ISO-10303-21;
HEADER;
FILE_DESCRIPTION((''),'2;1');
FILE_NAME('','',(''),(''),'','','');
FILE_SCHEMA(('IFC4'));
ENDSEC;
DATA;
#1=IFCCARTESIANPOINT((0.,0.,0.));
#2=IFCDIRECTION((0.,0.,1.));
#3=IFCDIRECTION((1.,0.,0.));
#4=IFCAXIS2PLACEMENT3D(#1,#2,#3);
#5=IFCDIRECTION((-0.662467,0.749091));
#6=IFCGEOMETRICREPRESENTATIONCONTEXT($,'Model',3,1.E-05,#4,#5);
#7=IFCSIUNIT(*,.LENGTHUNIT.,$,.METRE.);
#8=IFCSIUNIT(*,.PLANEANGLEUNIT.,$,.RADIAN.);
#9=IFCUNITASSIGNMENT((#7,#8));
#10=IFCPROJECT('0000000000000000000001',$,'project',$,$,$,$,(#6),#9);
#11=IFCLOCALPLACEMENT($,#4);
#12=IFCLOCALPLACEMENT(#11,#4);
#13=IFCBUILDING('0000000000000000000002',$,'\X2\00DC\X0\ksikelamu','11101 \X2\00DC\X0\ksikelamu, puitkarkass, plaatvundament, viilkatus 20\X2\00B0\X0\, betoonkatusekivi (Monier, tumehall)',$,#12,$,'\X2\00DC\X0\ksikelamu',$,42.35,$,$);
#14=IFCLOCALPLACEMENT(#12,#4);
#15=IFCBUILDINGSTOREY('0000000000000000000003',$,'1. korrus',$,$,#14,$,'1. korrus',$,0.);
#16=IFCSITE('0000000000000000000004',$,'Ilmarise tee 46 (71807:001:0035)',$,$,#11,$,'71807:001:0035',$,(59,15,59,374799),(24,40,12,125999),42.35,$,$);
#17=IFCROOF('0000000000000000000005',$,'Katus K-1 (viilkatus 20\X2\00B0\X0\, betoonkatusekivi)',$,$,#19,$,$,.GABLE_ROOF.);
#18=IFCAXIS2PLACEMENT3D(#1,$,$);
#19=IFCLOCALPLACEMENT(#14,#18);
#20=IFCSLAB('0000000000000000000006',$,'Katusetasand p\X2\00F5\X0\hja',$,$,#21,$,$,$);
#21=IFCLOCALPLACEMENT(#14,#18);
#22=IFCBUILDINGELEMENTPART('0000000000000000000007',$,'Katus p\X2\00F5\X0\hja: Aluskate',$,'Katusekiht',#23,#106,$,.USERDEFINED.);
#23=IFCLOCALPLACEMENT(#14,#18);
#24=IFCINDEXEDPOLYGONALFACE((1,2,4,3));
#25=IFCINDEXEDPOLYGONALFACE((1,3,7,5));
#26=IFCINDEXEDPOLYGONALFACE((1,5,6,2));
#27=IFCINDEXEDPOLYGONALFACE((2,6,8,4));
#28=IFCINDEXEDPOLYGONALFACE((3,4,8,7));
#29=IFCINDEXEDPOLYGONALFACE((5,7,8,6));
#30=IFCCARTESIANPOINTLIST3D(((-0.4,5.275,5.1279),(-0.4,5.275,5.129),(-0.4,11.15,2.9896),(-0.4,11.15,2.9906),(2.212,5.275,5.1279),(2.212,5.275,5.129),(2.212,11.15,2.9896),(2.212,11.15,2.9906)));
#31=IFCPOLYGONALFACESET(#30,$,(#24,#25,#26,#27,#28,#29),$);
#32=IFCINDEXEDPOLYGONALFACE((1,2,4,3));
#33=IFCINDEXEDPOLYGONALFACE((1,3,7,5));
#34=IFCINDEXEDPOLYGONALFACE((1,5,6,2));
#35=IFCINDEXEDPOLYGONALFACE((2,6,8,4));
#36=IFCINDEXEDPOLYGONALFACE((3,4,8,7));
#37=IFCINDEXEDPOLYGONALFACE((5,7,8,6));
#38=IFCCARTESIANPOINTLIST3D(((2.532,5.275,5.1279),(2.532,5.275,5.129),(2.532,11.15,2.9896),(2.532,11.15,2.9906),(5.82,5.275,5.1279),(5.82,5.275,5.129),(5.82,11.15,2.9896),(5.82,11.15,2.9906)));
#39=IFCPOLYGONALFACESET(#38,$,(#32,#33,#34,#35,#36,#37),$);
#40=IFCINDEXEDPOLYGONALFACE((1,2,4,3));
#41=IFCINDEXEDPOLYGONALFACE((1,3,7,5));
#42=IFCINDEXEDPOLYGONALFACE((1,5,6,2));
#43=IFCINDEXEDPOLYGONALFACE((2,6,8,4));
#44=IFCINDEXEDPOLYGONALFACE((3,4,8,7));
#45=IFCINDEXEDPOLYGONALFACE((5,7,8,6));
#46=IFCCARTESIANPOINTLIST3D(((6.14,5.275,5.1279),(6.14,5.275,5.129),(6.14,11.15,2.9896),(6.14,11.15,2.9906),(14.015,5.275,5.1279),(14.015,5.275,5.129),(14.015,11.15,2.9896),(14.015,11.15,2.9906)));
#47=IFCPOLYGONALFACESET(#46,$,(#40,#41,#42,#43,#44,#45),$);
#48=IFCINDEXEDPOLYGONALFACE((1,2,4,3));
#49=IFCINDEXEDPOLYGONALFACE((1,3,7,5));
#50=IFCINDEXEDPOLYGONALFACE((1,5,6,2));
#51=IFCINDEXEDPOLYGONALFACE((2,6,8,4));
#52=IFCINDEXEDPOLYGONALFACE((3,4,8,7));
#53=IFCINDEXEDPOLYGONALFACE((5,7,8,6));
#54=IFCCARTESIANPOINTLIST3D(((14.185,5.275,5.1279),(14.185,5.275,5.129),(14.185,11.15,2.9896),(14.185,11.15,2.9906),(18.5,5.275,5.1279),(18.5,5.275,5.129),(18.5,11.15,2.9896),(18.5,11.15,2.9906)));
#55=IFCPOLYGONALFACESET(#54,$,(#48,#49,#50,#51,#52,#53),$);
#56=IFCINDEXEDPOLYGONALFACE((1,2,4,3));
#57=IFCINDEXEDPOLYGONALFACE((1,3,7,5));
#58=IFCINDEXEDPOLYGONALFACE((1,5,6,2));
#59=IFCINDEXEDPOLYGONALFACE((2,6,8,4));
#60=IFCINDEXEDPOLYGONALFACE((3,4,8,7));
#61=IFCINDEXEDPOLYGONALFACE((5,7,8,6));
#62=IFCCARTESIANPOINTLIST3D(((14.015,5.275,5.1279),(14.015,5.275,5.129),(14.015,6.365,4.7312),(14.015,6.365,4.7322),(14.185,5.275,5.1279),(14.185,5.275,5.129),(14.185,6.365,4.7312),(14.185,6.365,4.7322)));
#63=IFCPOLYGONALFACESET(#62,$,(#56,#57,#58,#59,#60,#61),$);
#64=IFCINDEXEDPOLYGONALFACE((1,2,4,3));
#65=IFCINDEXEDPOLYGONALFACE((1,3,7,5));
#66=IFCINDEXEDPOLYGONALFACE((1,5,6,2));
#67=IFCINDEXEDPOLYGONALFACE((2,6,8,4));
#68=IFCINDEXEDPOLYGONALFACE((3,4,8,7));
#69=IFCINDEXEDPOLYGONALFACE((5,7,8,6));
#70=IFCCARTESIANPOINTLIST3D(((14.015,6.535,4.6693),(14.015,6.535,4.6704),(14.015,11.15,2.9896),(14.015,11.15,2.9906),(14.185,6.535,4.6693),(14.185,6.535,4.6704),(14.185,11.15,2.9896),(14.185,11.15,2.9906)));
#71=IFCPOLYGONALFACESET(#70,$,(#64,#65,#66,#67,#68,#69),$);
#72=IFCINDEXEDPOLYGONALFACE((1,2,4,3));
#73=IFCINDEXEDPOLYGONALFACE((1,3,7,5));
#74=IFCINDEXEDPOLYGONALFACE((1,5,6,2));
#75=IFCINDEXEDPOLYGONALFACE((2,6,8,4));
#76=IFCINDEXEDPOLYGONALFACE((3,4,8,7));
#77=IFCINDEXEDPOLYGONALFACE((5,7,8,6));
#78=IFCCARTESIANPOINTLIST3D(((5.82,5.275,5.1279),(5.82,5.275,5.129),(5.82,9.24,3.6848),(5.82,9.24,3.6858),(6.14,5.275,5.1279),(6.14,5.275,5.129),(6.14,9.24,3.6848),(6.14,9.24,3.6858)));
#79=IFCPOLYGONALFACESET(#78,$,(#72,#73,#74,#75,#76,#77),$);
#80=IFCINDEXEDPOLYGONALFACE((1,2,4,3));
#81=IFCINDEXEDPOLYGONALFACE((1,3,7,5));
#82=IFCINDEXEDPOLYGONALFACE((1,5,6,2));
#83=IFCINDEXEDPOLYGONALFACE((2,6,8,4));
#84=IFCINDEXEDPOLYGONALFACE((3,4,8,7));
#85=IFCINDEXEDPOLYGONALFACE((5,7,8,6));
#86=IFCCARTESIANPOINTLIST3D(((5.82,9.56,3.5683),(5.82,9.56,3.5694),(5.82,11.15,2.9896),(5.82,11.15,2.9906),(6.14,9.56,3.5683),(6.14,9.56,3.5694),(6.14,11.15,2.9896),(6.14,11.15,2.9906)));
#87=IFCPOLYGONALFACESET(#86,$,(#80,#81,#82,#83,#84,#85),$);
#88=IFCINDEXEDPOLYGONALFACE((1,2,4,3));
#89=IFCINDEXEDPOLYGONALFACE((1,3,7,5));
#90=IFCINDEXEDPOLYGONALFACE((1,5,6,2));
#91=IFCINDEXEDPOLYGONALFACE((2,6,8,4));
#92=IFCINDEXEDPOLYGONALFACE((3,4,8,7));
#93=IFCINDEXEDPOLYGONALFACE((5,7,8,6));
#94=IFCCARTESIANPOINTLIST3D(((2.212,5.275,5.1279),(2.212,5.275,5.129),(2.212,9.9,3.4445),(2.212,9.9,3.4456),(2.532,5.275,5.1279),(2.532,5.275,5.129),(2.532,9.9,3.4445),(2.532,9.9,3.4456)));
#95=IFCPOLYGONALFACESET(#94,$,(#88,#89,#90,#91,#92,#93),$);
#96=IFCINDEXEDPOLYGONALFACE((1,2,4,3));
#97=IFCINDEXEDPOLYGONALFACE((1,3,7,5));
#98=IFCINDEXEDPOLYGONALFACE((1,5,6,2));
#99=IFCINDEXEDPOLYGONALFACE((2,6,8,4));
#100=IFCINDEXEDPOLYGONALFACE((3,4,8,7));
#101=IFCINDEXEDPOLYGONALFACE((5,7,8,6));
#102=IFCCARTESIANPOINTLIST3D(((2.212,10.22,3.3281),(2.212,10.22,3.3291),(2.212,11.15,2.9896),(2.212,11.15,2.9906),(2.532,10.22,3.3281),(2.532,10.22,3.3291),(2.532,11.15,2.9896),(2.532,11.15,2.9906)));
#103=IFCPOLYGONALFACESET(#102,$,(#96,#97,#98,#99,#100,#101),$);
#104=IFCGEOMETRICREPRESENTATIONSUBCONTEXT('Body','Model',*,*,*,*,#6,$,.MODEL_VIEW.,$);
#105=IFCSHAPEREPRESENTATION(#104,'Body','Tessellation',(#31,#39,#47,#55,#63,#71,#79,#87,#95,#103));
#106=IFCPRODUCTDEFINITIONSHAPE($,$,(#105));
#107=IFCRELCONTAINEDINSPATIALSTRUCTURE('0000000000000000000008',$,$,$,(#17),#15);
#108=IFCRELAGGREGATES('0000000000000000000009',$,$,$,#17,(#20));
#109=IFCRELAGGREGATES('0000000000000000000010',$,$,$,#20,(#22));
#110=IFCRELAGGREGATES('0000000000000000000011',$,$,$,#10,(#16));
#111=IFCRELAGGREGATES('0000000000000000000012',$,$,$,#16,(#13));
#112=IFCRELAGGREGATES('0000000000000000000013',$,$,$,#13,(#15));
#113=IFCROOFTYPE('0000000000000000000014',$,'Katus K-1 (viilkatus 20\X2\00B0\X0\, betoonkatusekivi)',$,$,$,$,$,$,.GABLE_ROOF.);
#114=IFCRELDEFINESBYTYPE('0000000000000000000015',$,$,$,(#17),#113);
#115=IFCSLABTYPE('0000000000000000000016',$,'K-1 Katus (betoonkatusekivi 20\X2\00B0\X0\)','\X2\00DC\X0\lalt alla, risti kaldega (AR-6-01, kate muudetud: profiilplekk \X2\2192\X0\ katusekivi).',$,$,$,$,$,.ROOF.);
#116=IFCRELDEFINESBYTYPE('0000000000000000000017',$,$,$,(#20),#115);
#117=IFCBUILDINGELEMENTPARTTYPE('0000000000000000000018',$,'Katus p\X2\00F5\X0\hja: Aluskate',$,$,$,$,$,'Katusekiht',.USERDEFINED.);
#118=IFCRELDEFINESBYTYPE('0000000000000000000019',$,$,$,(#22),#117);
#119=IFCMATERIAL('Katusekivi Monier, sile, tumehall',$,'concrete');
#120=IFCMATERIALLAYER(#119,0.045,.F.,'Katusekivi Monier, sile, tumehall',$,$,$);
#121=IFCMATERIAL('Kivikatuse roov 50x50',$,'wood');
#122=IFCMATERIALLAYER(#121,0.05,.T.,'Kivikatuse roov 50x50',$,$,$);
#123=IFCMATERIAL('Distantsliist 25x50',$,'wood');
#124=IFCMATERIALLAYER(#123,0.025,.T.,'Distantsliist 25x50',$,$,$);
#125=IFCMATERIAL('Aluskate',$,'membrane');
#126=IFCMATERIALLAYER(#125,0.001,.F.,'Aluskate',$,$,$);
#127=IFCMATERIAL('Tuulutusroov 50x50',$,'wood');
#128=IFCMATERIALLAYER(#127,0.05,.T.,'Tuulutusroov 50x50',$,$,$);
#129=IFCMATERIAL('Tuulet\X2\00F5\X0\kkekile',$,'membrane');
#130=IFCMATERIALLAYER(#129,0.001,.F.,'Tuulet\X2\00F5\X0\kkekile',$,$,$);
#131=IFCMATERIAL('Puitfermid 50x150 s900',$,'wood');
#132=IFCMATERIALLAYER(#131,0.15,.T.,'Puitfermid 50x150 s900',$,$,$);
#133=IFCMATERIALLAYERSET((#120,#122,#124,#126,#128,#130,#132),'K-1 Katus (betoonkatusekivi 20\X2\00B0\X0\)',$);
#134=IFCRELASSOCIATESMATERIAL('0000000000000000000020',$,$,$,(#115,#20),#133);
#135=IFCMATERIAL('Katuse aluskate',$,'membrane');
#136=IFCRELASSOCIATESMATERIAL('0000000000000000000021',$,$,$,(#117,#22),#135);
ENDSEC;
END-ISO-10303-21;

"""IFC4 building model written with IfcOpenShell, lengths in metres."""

from ifc_helpers import new_model, si_unit, direction, frame, origin_with_axes, place, context, subcontext, project, spatial, indexed_curve, outline, extrude, material, layer, layer_set, layer_usage, type_object, element, aggregate, save


model = new_model("IFC4")

# Units and contexts
model_context = context("Model", 3, precision=1e-05, world=origin_with_axes(), true_north=direction((-0.662467, 0.749091)))
body_context = subcontext(model_context, "Body", "Model", "MODEL_VIEW")
ifc_project = project(units=[si_unit("LENGTHUNIT", "METRE"), si_unit("PLANEANGLEUNIT", "RADIAN")], contexts=[model_context])

# Site, building, storey
site_placement = place(None, origin_with_axes())
site = spatial("IfcSite", under=ifc_project, at=site_placement, Name="Ilmarise tee 46 (71807:001:0035)", LongName="71807:001:0035", RefLatitude=(59, 15, 59, 374799), RefLongitude=(24, 40, 12, 125999), RefElevation=42.35)
building_placement = place(site_placement, origin_with_axes())
building = spatial("IfcBuilding", under=site, at=building_placement, Name="Üksikelamu", Description="11101 Üksikelamu, puitkarkass, plaatvundament, viilkatus 20°, betoonkatusekivi (Monier, tumehall)", LongName="Üksikelamu", ElevationOfRefHeight=42.35)
storey_placement = place(building_placement, origin_with_axes())
storey = spatial("IfcBuildingStorey", under=building, at=storey_placement, Name="1. korrus", LongName="1. korrus", Elevation=0.0)

# Roof
roof_type = type_object("IfcRoofType", Name="Katus K-1 (viilkatus 20°, betoonkatusekivi)", PredefinedType="GABLE_ROOF")
roof_placement = place(storey_placement, origin_with_axes())
roof = element("IfcRoof", 1, at=roof_placement, inside=storey, type_object=roof_type, Name="Katus K-1 (viilkatus 20°, betoonkatusekivi)", PredefinedType="GABLE_ROOF")

# Shared definitions
ifc_material_1 = material(Name="Katusekivi Monier, sile, tumehall", Category="concrete")
ifc_layer_1 = layer(ifc_material_1, 0.045, ventilated=False, Name="Katusekivi Monier, sile, tumehall")
ifc_material_2 = material(Name="Kivikatuse roov 50x50", Category="wood")
ifc_layer_2 = layer(ifc_material_2, 0.05, ventilated=True, Name="Kivikatuse roov 50x50")
ifc_material_3 = material(Name="Distantsliist 25x50", Category="wood")
ifc_layer_3 = layer(ifc_material_3, 0.025, ventilated=True, Name="Distantsliist 25x50")
ifc_material_4 = material(Name="Aluskate", Category="membrane")
ifc_layer_4 = layer(ifc_material_4, 0.001, ventilated=False, Name="Aluskate")
ifc_material_5 = material(Name="Tuulutusroov 50x50", Category="wood")
ifc_layer_5 = layer(ifc_material_5, 0.05, ventilated=True, Name="Tuulutusroov 50x50")
ifc_material_6 = material(Name="Tuuletõkkekile", Category="membrane")
ifc_layer_6 = layer(ifc_material_6, 0.001, ventilated=False, Name="Tuuletõkkekile")
ifc_material_7 = material(Name="Puitfermid 50x150 s900", Category="wood")
ifc_layer_7 = layer(ifc_material_7, 0.15, ventilated=True, Name="Puitfermid 50x150 s900")
ifc_layer_set = layer_set([ifc_layer_1, ifc_layer_2, ifc_layer_3, ifc_layer_4, ifc_layer_5, ifc_layer_6, ifc_layer_7], Name="K-1 Katus (betoonkatusekivi 20°)")
slab_type = type_object("IfcSlabType", Name="K-1 Katus (betoonkatusekivi 20°)", Description="Ülalt alla, risti kaldega (AR-6-01, kate muudetud: profiilplekk → katusekivi).", PredefinedType="ROOF", material=ifc_layer_set)
ifc_material_8 = material(Name="Katuse aluskate", Category="membrane")

# Slab
ifc_layer_usage_1 = layer_usage(ifc_layer_set, "AXIS3", "POSITIVE", 0.0)
slab_1_placement = place(roof_placement, origin_with_axes())
slab_1 = element("IfcSlab", 2, at=slab_1_placement, type_object=slab_type, material=ifc_layer_usage_1, Name="Katusetasand põhja")
aggregate(roof, [slab_1])

# Building element part
building_element_part_type_1 = type_object("IfcBuildingElementPartType", Name="Katus põhja: Aluskate", ElementType="Katusekiht", PredefinedType="USERDEFINED", material=ifc_material_8)
building_element_part_1_placement = place(slab_1_placement, origin_with_axes())
building_element_part_1 = element("IfcBuildingElementPart", 3, at=building_element_part_1_placement, type_object=building_element_part_type_1, material=ifc_material_8, Name="Katus põhja: Aluskate", ObjectType="Katusekiht", PredefinedType="USERDEFINED", context=body_context, shape_type="SweptSolid", body=[
    extrude(outline(indexed_curve([(5.275, 5.1279), (11.15, 2.9896), (11.15, 2.9906), (5.275, 5.129), (5.275, 5.1279)], self_intersect=False)), frame((-0.4, 0.0, 0.0), z_axis=(1.0, 0.0, 0.0), x_axis=(0.0, 1.0, 0.0)), (0.0, 0.0, 1.0), 2.612),
    extrude(outline(indexed_curve([(5.275, 5.1279), (11.15, 2.9896), (11.15, 2.9906), (5.275, 5.129), (5.275, 5.1279)], self_intersect=False)), frame((2.532, 0.0, 0.0), z_axis=(1.0, 0.0, 0.0), x_axis=(0.0, 1.0, 0.0)), (0.0, 0.0, 1.0), 3.288),
    extrude(outline(indexed_curve([(5.275, 5.1279), (11.15, 2.9896), (11.15, 2.9906), (5.275, 5.129), (5.275, 5.1279)], self_intersect=False)), frame((6.14, 0.0, 0.0), z_axis=(1.0, 0.0, 0.0), x_axis=(0.0, 1.0, 0.0)), (0.0, 0.0, 1.0), 7.875),
    extrude(outline(indexed_curve([(5.275, 5.1279), (11.15, 2.9896), (11.15, 2.9906), (5.275, 5.129), (5.275, 5.1279)], self_intersect=False)), frame((14.185, 0.0, 0.0), z_axis=(1.0, 0.0, 0.0), x_axis=(0.0, 1.0, 0.0)), (0.0, 0.0, 1.0), 4.315),
    extrude(outline(indexed_curve([(5.275, 5.1279), (5.275, 5.129), (6.365, 4.7322), (6.365, 4.7312), (5.275, 5.1279)], self_intersect=False)), frame((14.015, 0.0, 0.0), z_axis=(1.0, 0.0, 0.0), x_axis=(0.0, 1.0, 0.0)), (0.0, 0.0, 1.0), 0.17),
    extrude(outline(indexed_curve([(11.15, 2.9906), (11.15, 2.9896), (6.535, 4.6693), (6.535, 4.6704), (11.15, 2.9906)], self_intersect=False)), frame((14.015, 0.0, 0.0), z_axis=(1.0, 0.0, 0.0), x_axis=(0.0, 1.0, 0.0)), (0.0, 0.0, 1.0), 0.17),
    extrude(outline(indexed_curve([(5.275, 5.1279), (5.275, 5.129), (9.24, 3.6858), (9.24, 3.6848), (5.275, 5.1279)], self_intersect=False)), frame((5.82, 0.0, 0.0), z_axis=(1.0, 0.0, 0.0), x_axis=(0.0, 1.0, 0.0)), (0.0, 0.0, 1.0), 0.32),
    extrude(outline(indexed_curve([(11.15, 2.9906), (11.15, 2.9896), (9.56, 3.5683), (9.56, 3.5694), (11.15, 2.9906)], self_intersect=False)), frame((5.82, 0.0, 0.0), z_axis=(1.0, 0.0, 0.0), x_axis=(0.0, 1.0, 0.0)), (0.0, 0.0, 1.0), 0.32),
    extrude(outline(indexed_curve([(5.275, 5.1279), (5.275, 5.129), (9.9, 3.4456), (9.9, 3.4445), (5.275, 5.1279)], self_intersect=False)), frame((2.212, 0.0, 0.0), z_axis=(1.0, 0.0, 0.0), x_axis=(0.0, 1.0, 0.0)), (0.0, 0.0, 1.0), 0.32),
    extrude(outline(indexed_curve([(11.15, 2.9906), (11.15, 2.9896), (10.22, 3.3281), (10.22, 3.3291), (11.15, 2.9906)], self_intersect=False)), frame((2.212, 0.0, 0.0), z_axis=(1.0, 0.0, 0.0), x_axis=(0.0, 1.0, 0.0)), (0.0, 0.0, 1.0), 0.32),
])
aggregate(slab_1, [building_element_part_1])

save(model, "model.ifc")
